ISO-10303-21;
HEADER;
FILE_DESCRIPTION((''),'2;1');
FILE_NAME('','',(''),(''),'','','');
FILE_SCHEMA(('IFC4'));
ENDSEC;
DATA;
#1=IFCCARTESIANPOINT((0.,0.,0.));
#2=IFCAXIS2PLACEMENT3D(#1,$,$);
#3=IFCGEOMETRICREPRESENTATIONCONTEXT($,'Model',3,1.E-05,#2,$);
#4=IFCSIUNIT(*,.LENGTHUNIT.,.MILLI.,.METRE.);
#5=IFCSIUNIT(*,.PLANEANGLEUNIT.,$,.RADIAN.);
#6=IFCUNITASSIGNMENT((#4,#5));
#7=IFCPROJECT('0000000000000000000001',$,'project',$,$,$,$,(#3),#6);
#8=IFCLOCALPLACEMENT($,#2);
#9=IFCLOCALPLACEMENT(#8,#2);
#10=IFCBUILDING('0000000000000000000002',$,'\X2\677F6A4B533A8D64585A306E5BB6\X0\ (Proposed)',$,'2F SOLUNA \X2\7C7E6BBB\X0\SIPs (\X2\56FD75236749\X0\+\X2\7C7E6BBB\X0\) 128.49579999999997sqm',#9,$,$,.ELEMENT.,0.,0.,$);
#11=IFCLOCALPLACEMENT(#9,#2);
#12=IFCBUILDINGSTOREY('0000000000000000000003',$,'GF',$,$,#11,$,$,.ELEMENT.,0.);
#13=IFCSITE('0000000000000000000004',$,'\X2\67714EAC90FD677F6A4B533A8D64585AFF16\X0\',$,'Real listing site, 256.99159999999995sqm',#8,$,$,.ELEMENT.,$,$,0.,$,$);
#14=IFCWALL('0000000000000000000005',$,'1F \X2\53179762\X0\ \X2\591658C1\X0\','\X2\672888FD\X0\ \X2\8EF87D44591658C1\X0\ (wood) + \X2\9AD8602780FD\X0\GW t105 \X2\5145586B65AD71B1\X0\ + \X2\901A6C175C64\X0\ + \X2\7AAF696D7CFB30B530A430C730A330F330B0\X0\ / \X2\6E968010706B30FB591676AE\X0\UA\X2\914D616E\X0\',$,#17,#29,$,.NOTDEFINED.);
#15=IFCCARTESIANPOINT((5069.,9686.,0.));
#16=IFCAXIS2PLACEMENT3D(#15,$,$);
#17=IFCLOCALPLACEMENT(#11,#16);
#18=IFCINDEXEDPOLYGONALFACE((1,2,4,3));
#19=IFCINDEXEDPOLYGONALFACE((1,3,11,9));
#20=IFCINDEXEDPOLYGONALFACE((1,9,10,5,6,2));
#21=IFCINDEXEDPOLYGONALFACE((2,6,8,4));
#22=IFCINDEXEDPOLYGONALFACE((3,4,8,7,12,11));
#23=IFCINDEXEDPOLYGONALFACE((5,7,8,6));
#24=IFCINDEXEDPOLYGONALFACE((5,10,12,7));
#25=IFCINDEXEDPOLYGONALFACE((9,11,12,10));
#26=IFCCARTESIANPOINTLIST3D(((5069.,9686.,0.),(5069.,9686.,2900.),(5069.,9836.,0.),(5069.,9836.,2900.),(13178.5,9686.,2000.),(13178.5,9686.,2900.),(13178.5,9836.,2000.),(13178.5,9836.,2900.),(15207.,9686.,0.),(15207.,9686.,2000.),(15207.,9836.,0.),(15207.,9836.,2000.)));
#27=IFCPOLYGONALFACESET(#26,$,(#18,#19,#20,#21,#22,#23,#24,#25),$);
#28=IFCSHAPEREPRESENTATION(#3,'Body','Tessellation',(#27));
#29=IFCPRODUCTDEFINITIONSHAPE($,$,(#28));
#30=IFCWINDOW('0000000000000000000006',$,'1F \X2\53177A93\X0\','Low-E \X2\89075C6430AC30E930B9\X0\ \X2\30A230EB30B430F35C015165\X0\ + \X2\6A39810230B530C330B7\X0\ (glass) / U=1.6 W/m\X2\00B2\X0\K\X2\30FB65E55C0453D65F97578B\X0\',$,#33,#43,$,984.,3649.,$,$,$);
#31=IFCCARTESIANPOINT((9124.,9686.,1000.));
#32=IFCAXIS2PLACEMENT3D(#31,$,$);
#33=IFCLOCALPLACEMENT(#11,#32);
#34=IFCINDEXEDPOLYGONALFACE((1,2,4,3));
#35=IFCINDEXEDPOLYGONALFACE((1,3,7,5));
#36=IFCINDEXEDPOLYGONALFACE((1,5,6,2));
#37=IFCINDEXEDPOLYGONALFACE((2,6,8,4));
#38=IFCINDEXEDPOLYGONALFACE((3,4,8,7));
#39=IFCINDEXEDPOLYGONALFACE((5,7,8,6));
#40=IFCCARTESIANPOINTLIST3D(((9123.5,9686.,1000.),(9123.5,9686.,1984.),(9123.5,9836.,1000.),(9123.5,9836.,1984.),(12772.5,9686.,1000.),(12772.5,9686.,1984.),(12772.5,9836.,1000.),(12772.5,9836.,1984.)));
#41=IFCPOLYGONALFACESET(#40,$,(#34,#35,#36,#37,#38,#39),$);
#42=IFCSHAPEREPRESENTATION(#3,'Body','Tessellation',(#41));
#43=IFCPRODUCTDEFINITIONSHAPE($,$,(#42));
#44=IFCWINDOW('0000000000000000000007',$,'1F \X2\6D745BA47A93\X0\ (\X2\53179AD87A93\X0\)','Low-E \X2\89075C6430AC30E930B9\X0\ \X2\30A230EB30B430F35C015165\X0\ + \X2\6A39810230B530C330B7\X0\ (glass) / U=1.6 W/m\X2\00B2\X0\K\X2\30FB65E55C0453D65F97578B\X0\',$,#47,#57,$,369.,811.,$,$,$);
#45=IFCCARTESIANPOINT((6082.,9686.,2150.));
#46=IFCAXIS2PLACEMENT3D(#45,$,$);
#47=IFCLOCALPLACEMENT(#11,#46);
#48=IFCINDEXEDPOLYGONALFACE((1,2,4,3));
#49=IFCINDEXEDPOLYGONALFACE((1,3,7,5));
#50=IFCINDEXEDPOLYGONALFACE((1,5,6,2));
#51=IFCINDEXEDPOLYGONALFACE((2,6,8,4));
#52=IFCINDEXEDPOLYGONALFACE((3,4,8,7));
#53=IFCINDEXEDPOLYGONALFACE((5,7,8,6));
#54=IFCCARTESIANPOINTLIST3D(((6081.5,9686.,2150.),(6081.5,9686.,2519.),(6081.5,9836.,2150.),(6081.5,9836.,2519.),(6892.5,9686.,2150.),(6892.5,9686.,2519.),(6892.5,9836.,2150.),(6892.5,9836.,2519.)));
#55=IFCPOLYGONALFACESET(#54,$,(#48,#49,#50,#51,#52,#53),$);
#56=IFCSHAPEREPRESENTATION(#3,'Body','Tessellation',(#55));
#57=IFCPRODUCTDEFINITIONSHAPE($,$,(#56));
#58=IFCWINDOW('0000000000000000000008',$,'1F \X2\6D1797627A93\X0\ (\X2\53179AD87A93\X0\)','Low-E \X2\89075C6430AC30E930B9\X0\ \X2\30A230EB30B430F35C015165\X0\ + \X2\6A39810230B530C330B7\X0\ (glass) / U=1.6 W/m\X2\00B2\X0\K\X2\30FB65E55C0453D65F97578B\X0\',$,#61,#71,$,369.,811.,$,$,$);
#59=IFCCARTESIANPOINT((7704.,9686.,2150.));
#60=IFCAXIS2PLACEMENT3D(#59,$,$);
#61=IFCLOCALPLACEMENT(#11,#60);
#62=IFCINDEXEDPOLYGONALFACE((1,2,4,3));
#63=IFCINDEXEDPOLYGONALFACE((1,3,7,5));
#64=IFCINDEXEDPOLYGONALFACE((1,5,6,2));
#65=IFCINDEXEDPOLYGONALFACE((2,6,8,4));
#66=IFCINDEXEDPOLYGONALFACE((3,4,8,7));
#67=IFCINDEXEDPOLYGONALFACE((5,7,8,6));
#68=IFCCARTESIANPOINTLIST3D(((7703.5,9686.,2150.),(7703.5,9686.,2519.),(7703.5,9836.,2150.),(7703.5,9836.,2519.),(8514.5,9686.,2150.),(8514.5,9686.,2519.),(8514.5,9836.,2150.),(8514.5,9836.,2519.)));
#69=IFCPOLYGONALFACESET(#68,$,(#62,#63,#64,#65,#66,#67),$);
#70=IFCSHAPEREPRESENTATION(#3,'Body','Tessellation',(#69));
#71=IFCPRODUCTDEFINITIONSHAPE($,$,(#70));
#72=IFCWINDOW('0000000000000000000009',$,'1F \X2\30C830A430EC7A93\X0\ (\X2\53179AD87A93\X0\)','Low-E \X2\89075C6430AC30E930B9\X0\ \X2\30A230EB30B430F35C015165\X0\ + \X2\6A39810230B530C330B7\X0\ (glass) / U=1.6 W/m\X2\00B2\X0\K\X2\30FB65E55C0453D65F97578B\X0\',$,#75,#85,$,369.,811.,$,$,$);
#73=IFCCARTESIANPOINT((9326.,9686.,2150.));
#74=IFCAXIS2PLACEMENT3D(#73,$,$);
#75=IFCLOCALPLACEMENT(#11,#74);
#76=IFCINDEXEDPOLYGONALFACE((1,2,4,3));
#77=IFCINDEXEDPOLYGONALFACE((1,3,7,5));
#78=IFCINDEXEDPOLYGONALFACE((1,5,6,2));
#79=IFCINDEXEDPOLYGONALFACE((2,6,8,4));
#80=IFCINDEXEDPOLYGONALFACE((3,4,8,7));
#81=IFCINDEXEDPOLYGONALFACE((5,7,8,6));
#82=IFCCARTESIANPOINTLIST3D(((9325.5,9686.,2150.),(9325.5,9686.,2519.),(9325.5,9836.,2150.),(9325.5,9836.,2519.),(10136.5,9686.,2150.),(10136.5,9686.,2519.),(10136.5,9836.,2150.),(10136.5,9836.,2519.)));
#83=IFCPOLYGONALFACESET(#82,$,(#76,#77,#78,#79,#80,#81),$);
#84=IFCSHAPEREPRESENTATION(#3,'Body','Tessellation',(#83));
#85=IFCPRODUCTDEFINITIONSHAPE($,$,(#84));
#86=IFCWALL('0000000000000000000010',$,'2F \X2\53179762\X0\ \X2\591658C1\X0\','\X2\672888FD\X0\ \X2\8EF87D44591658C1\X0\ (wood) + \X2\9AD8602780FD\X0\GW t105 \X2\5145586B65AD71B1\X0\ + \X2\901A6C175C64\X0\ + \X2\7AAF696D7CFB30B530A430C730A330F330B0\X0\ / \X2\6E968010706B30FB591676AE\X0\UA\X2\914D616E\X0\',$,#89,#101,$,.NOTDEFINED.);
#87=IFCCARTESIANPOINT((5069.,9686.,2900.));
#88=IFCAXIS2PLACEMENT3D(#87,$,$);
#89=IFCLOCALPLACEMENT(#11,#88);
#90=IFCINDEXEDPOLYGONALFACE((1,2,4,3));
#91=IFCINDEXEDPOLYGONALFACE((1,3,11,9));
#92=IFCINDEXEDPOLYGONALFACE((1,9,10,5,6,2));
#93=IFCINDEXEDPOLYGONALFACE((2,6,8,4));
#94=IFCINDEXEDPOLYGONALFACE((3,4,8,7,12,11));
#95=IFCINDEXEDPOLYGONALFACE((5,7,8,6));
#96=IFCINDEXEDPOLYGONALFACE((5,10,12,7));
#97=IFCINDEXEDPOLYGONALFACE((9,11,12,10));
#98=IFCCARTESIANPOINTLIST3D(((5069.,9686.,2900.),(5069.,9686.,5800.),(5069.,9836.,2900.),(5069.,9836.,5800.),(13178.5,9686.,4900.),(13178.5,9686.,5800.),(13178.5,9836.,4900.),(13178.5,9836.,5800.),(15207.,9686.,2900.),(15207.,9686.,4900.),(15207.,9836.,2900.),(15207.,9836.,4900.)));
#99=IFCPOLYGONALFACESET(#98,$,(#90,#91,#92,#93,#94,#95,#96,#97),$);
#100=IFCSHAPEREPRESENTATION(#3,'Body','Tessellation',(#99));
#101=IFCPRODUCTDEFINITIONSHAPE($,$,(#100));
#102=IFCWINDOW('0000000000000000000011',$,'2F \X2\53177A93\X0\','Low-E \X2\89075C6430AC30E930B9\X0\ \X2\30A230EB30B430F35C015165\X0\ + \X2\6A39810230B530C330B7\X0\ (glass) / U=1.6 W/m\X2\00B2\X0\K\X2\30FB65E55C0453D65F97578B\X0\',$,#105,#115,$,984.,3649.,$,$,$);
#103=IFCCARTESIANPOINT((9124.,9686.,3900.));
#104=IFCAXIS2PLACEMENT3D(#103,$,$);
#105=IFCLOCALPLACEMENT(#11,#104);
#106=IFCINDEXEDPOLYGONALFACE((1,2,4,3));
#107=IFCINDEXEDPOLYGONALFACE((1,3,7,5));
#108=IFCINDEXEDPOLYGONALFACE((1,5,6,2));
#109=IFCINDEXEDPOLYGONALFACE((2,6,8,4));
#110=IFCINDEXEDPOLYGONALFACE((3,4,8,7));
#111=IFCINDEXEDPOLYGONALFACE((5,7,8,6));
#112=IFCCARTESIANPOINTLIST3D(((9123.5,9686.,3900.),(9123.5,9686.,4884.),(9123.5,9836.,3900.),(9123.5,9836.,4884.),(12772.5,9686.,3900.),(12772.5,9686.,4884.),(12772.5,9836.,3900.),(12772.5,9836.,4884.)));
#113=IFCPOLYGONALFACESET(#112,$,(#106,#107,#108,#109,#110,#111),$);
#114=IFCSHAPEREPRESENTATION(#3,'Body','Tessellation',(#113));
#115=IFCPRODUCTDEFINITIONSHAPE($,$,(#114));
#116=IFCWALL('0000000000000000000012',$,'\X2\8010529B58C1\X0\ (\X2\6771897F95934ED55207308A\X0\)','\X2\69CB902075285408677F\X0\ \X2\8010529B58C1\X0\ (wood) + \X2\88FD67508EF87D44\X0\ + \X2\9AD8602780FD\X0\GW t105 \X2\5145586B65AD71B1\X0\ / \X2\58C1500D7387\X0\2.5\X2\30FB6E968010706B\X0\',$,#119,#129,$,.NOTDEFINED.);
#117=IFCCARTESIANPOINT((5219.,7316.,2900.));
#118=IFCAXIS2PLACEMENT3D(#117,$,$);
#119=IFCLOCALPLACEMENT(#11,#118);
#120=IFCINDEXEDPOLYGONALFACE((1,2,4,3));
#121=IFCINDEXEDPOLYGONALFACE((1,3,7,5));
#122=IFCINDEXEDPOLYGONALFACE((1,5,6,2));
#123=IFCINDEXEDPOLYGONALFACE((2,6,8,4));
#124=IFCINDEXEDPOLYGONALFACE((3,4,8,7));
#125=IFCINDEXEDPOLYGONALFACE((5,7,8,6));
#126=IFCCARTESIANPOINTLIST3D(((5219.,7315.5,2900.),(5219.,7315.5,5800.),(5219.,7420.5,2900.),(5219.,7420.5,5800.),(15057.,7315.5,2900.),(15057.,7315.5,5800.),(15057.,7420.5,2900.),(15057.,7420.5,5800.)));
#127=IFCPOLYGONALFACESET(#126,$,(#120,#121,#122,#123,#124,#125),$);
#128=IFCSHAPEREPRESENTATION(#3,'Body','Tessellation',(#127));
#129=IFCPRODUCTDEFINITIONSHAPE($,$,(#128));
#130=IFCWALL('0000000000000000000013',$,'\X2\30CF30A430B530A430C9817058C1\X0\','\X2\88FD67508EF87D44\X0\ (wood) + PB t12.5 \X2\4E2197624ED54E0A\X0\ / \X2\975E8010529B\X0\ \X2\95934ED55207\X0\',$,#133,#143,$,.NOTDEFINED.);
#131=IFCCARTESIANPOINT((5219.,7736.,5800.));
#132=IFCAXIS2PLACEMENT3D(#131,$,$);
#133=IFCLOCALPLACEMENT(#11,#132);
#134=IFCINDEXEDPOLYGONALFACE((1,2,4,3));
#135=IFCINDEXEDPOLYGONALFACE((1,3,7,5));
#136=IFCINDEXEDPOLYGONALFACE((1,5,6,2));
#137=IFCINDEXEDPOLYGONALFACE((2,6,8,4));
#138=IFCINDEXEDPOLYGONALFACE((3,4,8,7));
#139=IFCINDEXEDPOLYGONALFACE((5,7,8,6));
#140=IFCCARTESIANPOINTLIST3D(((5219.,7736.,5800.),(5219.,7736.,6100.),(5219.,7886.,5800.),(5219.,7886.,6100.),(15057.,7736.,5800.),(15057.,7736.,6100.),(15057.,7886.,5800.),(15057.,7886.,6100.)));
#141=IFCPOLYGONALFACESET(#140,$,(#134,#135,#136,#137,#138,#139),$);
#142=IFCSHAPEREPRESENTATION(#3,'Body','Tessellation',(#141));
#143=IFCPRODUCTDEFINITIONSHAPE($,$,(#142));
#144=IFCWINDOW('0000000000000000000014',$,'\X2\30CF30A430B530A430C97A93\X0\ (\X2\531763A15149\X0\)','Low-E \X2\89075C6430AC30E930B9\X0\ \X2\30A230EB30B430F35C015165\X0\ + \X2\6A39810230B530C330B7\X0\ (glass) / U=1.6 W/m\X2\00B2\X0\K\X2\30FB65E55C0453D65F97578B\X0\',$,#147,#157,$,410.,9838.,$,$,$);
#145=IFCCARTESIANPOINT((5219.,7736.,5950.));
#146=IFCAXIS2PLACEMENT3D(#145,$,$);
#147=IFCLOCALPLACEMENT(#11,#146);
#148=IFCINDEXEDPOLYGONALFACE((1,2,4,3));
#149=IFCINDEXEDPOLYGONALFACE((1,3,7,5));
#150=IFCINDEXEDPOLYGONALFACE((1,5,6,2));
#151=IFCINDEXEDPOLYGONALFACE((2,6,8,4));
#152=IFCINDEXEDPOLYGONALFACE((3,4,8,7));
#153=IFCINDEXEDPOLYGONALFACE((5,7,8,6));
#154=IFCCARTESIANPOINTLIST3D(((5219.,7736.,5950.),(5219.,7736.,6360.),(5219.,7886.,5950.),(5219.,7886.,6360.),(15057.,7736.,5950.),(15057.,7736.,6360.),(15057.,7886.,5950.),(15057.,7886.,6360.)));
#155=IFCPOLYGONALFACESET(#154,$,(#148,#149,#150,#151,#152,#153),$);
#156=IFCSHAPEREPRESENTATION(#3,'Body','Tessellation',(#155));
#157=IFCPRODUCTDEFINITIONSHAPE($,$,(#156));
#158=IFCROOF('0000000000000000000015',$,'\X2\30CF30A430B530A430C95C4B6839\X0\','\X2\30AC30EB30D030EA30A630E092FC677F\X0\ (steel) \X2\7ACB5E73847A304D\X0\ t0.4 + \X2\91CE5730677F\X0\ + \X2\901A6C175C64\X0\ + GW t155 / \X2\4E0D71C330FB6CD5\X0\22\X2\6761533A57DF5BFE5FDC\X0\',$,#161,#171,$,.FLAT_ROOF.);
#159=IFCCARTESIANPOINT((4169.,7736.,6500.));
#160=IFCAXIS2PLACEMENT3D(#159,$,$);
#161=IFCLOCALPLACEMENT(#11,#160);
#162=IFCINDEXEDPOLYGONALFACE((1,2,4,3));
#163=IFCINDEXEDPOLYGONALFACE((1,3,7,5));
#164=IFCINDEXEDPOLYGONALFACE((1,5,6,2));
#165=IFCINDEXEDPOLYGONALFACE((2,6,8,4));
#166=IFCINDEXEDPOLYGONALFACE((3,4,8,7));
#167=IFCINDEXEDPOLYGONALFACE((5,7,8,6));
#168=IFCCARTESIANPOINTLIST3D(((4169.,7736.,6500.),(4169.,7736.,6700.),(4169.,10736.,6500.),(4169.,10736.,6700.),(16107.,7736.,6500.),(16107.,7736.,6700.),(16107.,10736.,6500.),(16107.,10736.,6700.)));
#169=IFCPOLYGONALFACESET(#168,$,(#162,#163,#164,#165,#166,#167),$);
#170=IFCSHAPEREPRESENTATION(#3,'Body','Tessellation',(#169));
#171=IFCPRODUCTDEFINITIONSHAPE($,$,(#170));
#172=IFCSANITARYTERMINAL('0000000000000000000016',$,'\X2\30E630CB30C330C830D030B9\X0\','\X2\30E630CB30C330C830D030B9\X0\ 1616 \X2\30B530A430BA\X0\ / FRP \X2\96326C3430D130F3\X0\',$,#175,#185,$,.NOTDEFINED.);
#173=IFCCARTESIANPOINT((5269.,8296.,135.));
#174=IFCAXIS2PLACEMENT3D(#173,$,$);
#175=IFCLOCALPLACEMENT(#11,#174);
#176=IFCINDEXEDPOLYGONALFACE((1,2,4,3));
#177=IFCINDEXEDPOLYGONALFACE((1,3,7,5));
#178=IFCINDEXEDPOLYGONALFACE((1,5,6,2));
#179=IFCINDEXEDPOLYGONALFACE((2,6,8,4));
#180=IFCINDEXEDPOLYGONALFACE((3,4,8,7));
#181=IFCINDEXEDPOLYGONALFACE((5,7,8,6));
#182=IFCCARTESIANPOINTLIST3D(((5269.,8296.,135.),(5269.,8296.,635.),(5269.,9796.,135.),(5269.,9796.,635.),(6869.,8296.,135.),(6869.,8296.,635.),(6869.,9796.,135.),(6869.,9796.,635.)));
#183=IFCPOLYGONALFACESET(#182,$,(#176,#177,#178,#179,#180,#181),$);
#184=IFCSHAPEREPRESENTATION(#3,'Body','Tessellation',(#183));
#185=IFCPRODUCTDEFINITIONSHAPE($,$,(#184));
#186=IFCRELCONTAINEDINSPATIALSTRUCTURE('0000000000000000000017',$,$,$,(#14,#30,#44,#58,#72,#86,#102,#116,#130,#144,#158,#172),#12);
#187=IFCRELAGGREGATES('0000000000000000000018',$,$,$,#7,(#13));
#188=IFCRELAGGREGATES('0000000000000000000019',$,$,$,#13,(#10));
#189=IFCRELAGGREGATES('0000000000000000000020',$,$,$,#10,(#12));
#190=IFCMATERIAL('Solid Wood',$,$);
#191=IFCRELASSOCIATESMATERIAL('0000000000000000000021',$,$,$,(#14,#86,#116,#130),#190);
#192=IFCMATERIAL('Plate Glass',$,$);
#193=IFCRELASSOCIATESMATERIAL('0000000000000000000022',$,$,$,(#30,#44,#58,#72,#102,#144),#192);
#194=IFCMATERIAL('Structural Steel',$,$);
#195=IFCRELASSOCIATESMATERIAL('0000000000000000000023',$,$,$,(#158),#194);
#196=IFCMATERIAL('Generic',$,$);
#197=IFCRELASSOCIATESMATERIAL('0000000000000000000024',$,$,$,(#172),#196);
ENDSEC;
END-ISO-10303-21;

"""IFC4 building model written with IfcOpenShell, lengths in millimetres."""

from ifc_helpers import new_model, si_unit, frame, frame_2d, origin, place, context, project, spatial, rectangle, extrude, material, element, fill, save


model = new_model("IFC4")

# Units and contexts
model_context = context("Model", 3, precision=1e-05, world=origin())
ifc_project = project(units=[si_unit("LENGTHUNIT", "METRE", prefix="MILLI"), si_unit("PLANEANGLEUNIT", "RADIAN")], contexts=[model_context])

# Site, building, storey
site_placement = place(None, origin())
site = spatial("IfcSite", under=ifc_project, at=site_placement, Name="東京都板橋区赤塚６", ObjectType="Real listing site, 256.99159999999995sqm", CompositionType="ELEMENT", RefElevation=0.0)
building_placement = place(site_placement, origin())
building = spatial("IfcBuilding", under=site, at=building_placement, Name="板橋区赤塚の家 (Proposed)", ObjectType="2F SOLUNA 籾殻SIPs (国産杉+籾殻) 128.49579999999997sqm", CompositionType="ELEMENT", ElevationOfRefHeight=0.0, ElevationOfTerrain=0.0)
storey_placement = place(building_placement, origin())
storey = spatial("IfcBuildingStorey", under=building, at=storey_placement, Name="GF", CompositionType="ELEMENT", Elevation=0.0)

# Wall, openings, windows
ifc_material_1 = material(Name="Solid Wood")
wall_1_placement = place(storey_placement, frame((5069.0, 9686.0, 0.0)))
wall_1 = element("IfcWall", 1, at=wall_1_placement, inside=storey, material=ifc_material_1, Name="1F 北面 外壁", Description="木製 軸組外壁 (wood) + 高性能GW t105 充填断熱 + 通気層 + 窯業系サイディング / 準耐火・外皮UA配慮", PredefinedType="NOTDEFINED", context=model_context, shape_type="SweptSolid", body=[
    extrude(rectangle(XDim=10138.0, YDim=150.0, at=frame_2d((5069.0, 75.0))), frame((5069.0, 9686.0, 0.0)), (0.0, 0.0, 1.0), 2900.0),
])
opening_1_placement = place(storey_placement, frame((9124.0, 9686.0, 1000.0)))
opening_1 = element("IfcOpeningElement", 2, at=opening_1_placement, cuts=wall_1, PredefinedType="NOTDEFINED", context=model_context, shape_type="SweptSolid", body=[
    extrude(rectangle(XDim=3649.0, YDim=150.0, at=frame_2d((1824.0, 75.0))), frame((9124.0, 9686.0, 1000.0)), (0.0, 0.0, 1.0), 984.0),
])
opening_2_placement = place(storey_placement, frame((6082.0, 9686.0, 2150.0)))
opening_2 = element("IfcOpeningElement", 3, at=opening_2_placement, cuts=wall_1, PredefinedType="NOTDEFINED", context=model_context, shape_type="SweptSolid", body=[
    extrude(rectangle(XDim=811.0, YDim=150.0, at=frame_2d((405.0, 75.0))), frame((6082.0, 9686.0, 2150.0)), (0.0, 0.0, 1.0), 369.0),
])
opening_3_placement = place(storey_placement, frame((7704.0, 9686.0, 2150.0)))
opening_3 = element("IfcOpeningElement", 4, at=opening_3_placement, cuts=wall_1, PredefinedType="NOTDEFINED", context=model_context, shape_type="SweptSolid", body=[
    extrude(rectangle(XDim=811.0, YDim=150.0, at=frame_2d((405.0, 75.0))), frame((7704.0, 9686.0, 2150.0)), (0.0, 0.0, 1.0), 369.0),
])
opening_4_placement = place(storey_placement, frame((9326.0, 9686.0, 2150.0)))
opening_4 = element("IfcOpeningElement", 5, at=opening_4_placement, cuts=wall_1, PredefinedType="NOTDEFINED", context=model_context, shape_type="SweptSolid", body=[
    extrude(rectangle(XDim=811.0, YDim=150.0, at=frame_2d((405.0, 75.0))), frame((9326.0, 9686.0, 2150.0)), (0.0, 0.0, 1.0), 369.0),
])
ifc_material_2 = material(Name="Plate Glass")
window_1_placement = place(storey_placement, frame((9124.0, 9686.0, 1000.0)))
window_1 = element("IfcWindow", 6, at=window_1_placement, inside=storey, material=ifc_material_2, Name="1F 北窓", Description="Low-E 複層ガラス アルゴン封入 + 樹脂サッシ (glass) / U=1.6 W/m²K・日射取得型", OverallHeight=984.0, OverallWidth=3649.0, context=model_context, shape_type="SweptSolid", body=[
    extrude(rectangle(XDim=3649.0, YDim=150.0, at=frame_2d((1824.0, 75.0))), frame((9124.0, 9686.0, 1000.0)), (0.0, 0.0, 1.0), 984.0),
])
fill(opening_1, window_1)
window_2_placement = place(storey_placement, frame((6082.0, 9686.0, 2150.0)))
window_2 = element("IfcWindow", 7, at=window_2_placement, inside=storey, material=ifc_material_2, Name="1F 浴室窓 (北高窓)", Description="Low-E 複層ガラス アルゴン封入 + 樹脂サッシ (glass) / U=1.6 W/m²K・日射取得型", OverallHeight=369.0, OverallWidth=811.0, context=model_context, shape_type="SweptSolid", body=[
    extrude(rectangle(XDim=811.0, YDim=150.0, at=frame_2d((405.0, 75.0))), frame((6082.0, 9686.0, 2150.0)), (0.0, 0.0, 1.0), 369.0),
])
fill(opening_2, window_2)
window_3_placement = place(storey_placement, frame((7704.0, 9686.0, 2150.0)))
window_3 = element("IfcWindow", 8, at=window_3_placement, inside=storey, material=ifc_material_2, Name="1F 洗面窓 (北高窓)", Description="Low-E 複層ガラス アルゴン封入 + 樹脂サッシ (glass) / U=1.6 W/m²K・日射取得型", OverallHeight=369.0, OverallWidth=811.0, context=model_context, shape_type="SweptSolid", body=[
    extrude(rectangle(XDim=811.0, YDim=150.0, at=frame_2d((405.0, 75.0))), frame((7704.0, 9686.0, 2150.0)), (0.0, 0.0, 1.0), 369.0),
])
fill(opening_3, window_3)
window_4_placement = place(storey_placement, frame((9326.0, 9686.0, 2150.0)))
window_4 = element("IfcWindow", 9, at=window_4_placement, inside=storey, material=ifc_material_2, Name="1F トイレ窓 (北高窓)", Description="Low-E 複層ガラス アルゴン封入 + 樹脂サッシ (glass) / U=1.6 W/m²K・日射取得型", OverallHeight=369.0, OverallWidth=811.0, context=model_context, shape_type="SweptSolid", body=[
    extrude(rectangle(XDim=811.0, YDim=150.0, at=frame_2d((405.0, 75.0))), frame((9326.0, 9686.0, 2150.0)), (0.0, 0.0, 1.0), 369.0),
])
fill(opening_4, window_4)

# Wall, opening, window
wall_2_placement = place(storey_placement, frame((5069.0, 9686.0, 2900.0)))
wall_2 = element("IfcWall", 10, at=wall_2_placement, inside=storey, material=ifc_material_1, Name="2F 北面 外壁", Description="木製 軸組外壁 (wood) + 高性能GW t105 充填断熱 + 通気層 + 窯業系サイディング / 準耐火・外皮UA配慮", PredefinedType="NOTDEFINED", context=model_context, shape_type="SweptSolid", body=[
    extrude(rectangle(XDim=10138.0, YDim=150.0, at=frame_2d((5069.0, 75.0))), frame((5069.0, 9686.0, 2900.0)), (0.0, 0.0, 1.0), 2900.0),
])
opening_5_placement = place(storey_placement, frame((9124.0, 9686.0, 3900.0)))
opening_5 = element("IfcOpeningElement", 11, at=opening_5_placement, cuts=wall_2, PredefinedType="NOTDEFINED", context=model_context, shape_type="SweptSolid", body=[
    extrude(rectangle(XDim=3649.0, YDim=150.0, at=frame_2d((1824.0, 75.0))), frame((9124.0, 9686.0, 3900.0)), (0.0, 0.0, 1.0), 984.0),
])
window_5_placement = place(storey_placement, frame((9124.0, 9686.0, 3900.0)))
window_5 = element("IfcWindow", 12, at=window_5_placement, inside=storey, material=ifc_material_2, Name="2F 北窓", Description="Low-E 複層ガラス アルゴン封入 + 樹脂サッシ (glass) / U=1.6 W/m²K・日射取得型", OverallHeight=984.0, OverallWidth=3649.0, context=model_context, shape_type="SweptSolid", body=[
    extrude(rectangle(XDim=3649.0, YDim=150.0, at=frame_2d((1824.0, 75.0))), frame((9124.0, 9686.0, 3900.0)), (0.0, 0.0, 1.0), 984.0),
])
fill(opening_5, window_5)

# Wall
wall_3_placement = place(storey_placement, frame((5219.0, 7316.0, 2900.0)))
element("IfcWall", 13, at=wall_3_placement, inside=storey, material=ifc_material_1, Name="耐力壁 (東西間仕切り)", Description="構造用合板 耐力壁 (wood) + 製材軸組 + 高性能GW t105 充填断熱 / 壁倍率2.5・準耐火", PredefinedType="NOTDEFINED", context=model_context, shape_type="SweptSolid", body=[
    extrude(rectangle(XDim=9838.0, YDim=105.0, at=frame_2d((4919.0, 52.0))), frame((5219.0, 7316.0, 2900.0)), (0.0, 0.0, 1.0), 2900.0),
])

# Wall, opening, window
wall_4_placement = place(storey_placement, frame((5219.0, 7736.0, 5800.0)))
wall_4 = element("IfcWall", 14, at=wall_4_placement, inside=storey, material=ifc_material_1, Name="ハイサイド腰壁", Description="製材軸組 (wood) + PB t12.5 両面仕上 / 非耐力 間仕切", PredefinedType="NOTDEFINED", context=model_context, shape_type="SweptSolid", body=[
    extrude(rectangle(XDim=9838.0, YDim=150.0, at=frame_2d((4919.0, 75.0))), frame((5219.0, 7736.0, 5800.0)), (0.0, 0.0, 1.0), 700.0),
])
opening_6_placement = place(storey_placement, frame((5219.0, 7736.0, 5950.0)))
opening_6 = element("IfcOpeningElement", 15, at=opening_6_placement, cuts=wall_4, PredefinedType="NOTDEFINED", context=model_context, shape_type="SweptSolid", body=[
    extrude(rectangle(XDim=9838.0, YDim=150.0, at=frame_2d((4919.0, 75.0))), frame((5219.0, 7736.0, 5950.0)), (0.0, 0.0, 1.0), 410.0),
])
window_6_placement = place(storey_placement, frame((5219.0, 7736.0, 5950.0)))
window_6 = element("IfcWindow", 16, at=window_6_placement, inside=storey, material=ifc_material_2, Name="ハイサイド窓 (北採光)", Description="Low-E 複層ガラス アルゴン封入 + 樹脂サッシ (glass) / U=1.6 W/m²K・日射取得型", OverallHeight=410.0, OverallWidth=9838.0, context=model_context, shape_type="SweptSolid", body=[
    extrude(rectangle(XDim=9838.0, YDim=150.0, at=frame_2d((4919.0, 75.0))), frame((5219.0, 7736.0, 5950.0)), (0.0, 0.0, 1.0), 410.0),
])
fill(opening_6, window_6)

# Roof
ifc_material_3 = material(Name="Structural Steel")
roof_placement = place(storey_placement, frame((4169.0, 7736.0, 6500.0)))
element("IfcRoof", 17, at=roof_placement, inside=storey, material=ifc_material_3, Name="ハイサイド屋根", Description="ガルバリウム鋼板 (steel) 立平葺き t0.4 + 野地板 + 通気層 + GW t155 / 不燃・法22条区域対応", PredefinedType="FLAT_ROOF", context=model_context, shape_type="SweptSolid", body=[
    extrude(rectangle(XDim=11938.0, YDim=3000.0, at=frame_2d((5969.0, 1500.0))), frame((4169.0, 7736.0, 6500.0)), (0.0, 0.0, 1.0), 200.0),
])

# Sanitary terminal
ifc_material_4 = material(Name="Generic")
sanitary_terminal_placement = place(storey_placement, frame((5269.0, 8296.0, 135.0)))
element("IfcSanitaryTerminal", 18, at=sanitary_terminal_placement, inside=storey, material=ifc_material_4, Name="ユニットバス", Description="ユニットバス 1616 サイズ / FRP 防水パン", PredefinedType="NOTDEFINED", context=model_context, shape_type="SweptSolid", body=[
    extrude(rectangle(XDim=1600.0, YDim=1500.0, at=frame_2d((800.0, 750.0))), frame((5269.0, 8296.0, 135.0)), (0.0, 0.0, 1.0), 500.0),
])

save(model, "model.ifc")
